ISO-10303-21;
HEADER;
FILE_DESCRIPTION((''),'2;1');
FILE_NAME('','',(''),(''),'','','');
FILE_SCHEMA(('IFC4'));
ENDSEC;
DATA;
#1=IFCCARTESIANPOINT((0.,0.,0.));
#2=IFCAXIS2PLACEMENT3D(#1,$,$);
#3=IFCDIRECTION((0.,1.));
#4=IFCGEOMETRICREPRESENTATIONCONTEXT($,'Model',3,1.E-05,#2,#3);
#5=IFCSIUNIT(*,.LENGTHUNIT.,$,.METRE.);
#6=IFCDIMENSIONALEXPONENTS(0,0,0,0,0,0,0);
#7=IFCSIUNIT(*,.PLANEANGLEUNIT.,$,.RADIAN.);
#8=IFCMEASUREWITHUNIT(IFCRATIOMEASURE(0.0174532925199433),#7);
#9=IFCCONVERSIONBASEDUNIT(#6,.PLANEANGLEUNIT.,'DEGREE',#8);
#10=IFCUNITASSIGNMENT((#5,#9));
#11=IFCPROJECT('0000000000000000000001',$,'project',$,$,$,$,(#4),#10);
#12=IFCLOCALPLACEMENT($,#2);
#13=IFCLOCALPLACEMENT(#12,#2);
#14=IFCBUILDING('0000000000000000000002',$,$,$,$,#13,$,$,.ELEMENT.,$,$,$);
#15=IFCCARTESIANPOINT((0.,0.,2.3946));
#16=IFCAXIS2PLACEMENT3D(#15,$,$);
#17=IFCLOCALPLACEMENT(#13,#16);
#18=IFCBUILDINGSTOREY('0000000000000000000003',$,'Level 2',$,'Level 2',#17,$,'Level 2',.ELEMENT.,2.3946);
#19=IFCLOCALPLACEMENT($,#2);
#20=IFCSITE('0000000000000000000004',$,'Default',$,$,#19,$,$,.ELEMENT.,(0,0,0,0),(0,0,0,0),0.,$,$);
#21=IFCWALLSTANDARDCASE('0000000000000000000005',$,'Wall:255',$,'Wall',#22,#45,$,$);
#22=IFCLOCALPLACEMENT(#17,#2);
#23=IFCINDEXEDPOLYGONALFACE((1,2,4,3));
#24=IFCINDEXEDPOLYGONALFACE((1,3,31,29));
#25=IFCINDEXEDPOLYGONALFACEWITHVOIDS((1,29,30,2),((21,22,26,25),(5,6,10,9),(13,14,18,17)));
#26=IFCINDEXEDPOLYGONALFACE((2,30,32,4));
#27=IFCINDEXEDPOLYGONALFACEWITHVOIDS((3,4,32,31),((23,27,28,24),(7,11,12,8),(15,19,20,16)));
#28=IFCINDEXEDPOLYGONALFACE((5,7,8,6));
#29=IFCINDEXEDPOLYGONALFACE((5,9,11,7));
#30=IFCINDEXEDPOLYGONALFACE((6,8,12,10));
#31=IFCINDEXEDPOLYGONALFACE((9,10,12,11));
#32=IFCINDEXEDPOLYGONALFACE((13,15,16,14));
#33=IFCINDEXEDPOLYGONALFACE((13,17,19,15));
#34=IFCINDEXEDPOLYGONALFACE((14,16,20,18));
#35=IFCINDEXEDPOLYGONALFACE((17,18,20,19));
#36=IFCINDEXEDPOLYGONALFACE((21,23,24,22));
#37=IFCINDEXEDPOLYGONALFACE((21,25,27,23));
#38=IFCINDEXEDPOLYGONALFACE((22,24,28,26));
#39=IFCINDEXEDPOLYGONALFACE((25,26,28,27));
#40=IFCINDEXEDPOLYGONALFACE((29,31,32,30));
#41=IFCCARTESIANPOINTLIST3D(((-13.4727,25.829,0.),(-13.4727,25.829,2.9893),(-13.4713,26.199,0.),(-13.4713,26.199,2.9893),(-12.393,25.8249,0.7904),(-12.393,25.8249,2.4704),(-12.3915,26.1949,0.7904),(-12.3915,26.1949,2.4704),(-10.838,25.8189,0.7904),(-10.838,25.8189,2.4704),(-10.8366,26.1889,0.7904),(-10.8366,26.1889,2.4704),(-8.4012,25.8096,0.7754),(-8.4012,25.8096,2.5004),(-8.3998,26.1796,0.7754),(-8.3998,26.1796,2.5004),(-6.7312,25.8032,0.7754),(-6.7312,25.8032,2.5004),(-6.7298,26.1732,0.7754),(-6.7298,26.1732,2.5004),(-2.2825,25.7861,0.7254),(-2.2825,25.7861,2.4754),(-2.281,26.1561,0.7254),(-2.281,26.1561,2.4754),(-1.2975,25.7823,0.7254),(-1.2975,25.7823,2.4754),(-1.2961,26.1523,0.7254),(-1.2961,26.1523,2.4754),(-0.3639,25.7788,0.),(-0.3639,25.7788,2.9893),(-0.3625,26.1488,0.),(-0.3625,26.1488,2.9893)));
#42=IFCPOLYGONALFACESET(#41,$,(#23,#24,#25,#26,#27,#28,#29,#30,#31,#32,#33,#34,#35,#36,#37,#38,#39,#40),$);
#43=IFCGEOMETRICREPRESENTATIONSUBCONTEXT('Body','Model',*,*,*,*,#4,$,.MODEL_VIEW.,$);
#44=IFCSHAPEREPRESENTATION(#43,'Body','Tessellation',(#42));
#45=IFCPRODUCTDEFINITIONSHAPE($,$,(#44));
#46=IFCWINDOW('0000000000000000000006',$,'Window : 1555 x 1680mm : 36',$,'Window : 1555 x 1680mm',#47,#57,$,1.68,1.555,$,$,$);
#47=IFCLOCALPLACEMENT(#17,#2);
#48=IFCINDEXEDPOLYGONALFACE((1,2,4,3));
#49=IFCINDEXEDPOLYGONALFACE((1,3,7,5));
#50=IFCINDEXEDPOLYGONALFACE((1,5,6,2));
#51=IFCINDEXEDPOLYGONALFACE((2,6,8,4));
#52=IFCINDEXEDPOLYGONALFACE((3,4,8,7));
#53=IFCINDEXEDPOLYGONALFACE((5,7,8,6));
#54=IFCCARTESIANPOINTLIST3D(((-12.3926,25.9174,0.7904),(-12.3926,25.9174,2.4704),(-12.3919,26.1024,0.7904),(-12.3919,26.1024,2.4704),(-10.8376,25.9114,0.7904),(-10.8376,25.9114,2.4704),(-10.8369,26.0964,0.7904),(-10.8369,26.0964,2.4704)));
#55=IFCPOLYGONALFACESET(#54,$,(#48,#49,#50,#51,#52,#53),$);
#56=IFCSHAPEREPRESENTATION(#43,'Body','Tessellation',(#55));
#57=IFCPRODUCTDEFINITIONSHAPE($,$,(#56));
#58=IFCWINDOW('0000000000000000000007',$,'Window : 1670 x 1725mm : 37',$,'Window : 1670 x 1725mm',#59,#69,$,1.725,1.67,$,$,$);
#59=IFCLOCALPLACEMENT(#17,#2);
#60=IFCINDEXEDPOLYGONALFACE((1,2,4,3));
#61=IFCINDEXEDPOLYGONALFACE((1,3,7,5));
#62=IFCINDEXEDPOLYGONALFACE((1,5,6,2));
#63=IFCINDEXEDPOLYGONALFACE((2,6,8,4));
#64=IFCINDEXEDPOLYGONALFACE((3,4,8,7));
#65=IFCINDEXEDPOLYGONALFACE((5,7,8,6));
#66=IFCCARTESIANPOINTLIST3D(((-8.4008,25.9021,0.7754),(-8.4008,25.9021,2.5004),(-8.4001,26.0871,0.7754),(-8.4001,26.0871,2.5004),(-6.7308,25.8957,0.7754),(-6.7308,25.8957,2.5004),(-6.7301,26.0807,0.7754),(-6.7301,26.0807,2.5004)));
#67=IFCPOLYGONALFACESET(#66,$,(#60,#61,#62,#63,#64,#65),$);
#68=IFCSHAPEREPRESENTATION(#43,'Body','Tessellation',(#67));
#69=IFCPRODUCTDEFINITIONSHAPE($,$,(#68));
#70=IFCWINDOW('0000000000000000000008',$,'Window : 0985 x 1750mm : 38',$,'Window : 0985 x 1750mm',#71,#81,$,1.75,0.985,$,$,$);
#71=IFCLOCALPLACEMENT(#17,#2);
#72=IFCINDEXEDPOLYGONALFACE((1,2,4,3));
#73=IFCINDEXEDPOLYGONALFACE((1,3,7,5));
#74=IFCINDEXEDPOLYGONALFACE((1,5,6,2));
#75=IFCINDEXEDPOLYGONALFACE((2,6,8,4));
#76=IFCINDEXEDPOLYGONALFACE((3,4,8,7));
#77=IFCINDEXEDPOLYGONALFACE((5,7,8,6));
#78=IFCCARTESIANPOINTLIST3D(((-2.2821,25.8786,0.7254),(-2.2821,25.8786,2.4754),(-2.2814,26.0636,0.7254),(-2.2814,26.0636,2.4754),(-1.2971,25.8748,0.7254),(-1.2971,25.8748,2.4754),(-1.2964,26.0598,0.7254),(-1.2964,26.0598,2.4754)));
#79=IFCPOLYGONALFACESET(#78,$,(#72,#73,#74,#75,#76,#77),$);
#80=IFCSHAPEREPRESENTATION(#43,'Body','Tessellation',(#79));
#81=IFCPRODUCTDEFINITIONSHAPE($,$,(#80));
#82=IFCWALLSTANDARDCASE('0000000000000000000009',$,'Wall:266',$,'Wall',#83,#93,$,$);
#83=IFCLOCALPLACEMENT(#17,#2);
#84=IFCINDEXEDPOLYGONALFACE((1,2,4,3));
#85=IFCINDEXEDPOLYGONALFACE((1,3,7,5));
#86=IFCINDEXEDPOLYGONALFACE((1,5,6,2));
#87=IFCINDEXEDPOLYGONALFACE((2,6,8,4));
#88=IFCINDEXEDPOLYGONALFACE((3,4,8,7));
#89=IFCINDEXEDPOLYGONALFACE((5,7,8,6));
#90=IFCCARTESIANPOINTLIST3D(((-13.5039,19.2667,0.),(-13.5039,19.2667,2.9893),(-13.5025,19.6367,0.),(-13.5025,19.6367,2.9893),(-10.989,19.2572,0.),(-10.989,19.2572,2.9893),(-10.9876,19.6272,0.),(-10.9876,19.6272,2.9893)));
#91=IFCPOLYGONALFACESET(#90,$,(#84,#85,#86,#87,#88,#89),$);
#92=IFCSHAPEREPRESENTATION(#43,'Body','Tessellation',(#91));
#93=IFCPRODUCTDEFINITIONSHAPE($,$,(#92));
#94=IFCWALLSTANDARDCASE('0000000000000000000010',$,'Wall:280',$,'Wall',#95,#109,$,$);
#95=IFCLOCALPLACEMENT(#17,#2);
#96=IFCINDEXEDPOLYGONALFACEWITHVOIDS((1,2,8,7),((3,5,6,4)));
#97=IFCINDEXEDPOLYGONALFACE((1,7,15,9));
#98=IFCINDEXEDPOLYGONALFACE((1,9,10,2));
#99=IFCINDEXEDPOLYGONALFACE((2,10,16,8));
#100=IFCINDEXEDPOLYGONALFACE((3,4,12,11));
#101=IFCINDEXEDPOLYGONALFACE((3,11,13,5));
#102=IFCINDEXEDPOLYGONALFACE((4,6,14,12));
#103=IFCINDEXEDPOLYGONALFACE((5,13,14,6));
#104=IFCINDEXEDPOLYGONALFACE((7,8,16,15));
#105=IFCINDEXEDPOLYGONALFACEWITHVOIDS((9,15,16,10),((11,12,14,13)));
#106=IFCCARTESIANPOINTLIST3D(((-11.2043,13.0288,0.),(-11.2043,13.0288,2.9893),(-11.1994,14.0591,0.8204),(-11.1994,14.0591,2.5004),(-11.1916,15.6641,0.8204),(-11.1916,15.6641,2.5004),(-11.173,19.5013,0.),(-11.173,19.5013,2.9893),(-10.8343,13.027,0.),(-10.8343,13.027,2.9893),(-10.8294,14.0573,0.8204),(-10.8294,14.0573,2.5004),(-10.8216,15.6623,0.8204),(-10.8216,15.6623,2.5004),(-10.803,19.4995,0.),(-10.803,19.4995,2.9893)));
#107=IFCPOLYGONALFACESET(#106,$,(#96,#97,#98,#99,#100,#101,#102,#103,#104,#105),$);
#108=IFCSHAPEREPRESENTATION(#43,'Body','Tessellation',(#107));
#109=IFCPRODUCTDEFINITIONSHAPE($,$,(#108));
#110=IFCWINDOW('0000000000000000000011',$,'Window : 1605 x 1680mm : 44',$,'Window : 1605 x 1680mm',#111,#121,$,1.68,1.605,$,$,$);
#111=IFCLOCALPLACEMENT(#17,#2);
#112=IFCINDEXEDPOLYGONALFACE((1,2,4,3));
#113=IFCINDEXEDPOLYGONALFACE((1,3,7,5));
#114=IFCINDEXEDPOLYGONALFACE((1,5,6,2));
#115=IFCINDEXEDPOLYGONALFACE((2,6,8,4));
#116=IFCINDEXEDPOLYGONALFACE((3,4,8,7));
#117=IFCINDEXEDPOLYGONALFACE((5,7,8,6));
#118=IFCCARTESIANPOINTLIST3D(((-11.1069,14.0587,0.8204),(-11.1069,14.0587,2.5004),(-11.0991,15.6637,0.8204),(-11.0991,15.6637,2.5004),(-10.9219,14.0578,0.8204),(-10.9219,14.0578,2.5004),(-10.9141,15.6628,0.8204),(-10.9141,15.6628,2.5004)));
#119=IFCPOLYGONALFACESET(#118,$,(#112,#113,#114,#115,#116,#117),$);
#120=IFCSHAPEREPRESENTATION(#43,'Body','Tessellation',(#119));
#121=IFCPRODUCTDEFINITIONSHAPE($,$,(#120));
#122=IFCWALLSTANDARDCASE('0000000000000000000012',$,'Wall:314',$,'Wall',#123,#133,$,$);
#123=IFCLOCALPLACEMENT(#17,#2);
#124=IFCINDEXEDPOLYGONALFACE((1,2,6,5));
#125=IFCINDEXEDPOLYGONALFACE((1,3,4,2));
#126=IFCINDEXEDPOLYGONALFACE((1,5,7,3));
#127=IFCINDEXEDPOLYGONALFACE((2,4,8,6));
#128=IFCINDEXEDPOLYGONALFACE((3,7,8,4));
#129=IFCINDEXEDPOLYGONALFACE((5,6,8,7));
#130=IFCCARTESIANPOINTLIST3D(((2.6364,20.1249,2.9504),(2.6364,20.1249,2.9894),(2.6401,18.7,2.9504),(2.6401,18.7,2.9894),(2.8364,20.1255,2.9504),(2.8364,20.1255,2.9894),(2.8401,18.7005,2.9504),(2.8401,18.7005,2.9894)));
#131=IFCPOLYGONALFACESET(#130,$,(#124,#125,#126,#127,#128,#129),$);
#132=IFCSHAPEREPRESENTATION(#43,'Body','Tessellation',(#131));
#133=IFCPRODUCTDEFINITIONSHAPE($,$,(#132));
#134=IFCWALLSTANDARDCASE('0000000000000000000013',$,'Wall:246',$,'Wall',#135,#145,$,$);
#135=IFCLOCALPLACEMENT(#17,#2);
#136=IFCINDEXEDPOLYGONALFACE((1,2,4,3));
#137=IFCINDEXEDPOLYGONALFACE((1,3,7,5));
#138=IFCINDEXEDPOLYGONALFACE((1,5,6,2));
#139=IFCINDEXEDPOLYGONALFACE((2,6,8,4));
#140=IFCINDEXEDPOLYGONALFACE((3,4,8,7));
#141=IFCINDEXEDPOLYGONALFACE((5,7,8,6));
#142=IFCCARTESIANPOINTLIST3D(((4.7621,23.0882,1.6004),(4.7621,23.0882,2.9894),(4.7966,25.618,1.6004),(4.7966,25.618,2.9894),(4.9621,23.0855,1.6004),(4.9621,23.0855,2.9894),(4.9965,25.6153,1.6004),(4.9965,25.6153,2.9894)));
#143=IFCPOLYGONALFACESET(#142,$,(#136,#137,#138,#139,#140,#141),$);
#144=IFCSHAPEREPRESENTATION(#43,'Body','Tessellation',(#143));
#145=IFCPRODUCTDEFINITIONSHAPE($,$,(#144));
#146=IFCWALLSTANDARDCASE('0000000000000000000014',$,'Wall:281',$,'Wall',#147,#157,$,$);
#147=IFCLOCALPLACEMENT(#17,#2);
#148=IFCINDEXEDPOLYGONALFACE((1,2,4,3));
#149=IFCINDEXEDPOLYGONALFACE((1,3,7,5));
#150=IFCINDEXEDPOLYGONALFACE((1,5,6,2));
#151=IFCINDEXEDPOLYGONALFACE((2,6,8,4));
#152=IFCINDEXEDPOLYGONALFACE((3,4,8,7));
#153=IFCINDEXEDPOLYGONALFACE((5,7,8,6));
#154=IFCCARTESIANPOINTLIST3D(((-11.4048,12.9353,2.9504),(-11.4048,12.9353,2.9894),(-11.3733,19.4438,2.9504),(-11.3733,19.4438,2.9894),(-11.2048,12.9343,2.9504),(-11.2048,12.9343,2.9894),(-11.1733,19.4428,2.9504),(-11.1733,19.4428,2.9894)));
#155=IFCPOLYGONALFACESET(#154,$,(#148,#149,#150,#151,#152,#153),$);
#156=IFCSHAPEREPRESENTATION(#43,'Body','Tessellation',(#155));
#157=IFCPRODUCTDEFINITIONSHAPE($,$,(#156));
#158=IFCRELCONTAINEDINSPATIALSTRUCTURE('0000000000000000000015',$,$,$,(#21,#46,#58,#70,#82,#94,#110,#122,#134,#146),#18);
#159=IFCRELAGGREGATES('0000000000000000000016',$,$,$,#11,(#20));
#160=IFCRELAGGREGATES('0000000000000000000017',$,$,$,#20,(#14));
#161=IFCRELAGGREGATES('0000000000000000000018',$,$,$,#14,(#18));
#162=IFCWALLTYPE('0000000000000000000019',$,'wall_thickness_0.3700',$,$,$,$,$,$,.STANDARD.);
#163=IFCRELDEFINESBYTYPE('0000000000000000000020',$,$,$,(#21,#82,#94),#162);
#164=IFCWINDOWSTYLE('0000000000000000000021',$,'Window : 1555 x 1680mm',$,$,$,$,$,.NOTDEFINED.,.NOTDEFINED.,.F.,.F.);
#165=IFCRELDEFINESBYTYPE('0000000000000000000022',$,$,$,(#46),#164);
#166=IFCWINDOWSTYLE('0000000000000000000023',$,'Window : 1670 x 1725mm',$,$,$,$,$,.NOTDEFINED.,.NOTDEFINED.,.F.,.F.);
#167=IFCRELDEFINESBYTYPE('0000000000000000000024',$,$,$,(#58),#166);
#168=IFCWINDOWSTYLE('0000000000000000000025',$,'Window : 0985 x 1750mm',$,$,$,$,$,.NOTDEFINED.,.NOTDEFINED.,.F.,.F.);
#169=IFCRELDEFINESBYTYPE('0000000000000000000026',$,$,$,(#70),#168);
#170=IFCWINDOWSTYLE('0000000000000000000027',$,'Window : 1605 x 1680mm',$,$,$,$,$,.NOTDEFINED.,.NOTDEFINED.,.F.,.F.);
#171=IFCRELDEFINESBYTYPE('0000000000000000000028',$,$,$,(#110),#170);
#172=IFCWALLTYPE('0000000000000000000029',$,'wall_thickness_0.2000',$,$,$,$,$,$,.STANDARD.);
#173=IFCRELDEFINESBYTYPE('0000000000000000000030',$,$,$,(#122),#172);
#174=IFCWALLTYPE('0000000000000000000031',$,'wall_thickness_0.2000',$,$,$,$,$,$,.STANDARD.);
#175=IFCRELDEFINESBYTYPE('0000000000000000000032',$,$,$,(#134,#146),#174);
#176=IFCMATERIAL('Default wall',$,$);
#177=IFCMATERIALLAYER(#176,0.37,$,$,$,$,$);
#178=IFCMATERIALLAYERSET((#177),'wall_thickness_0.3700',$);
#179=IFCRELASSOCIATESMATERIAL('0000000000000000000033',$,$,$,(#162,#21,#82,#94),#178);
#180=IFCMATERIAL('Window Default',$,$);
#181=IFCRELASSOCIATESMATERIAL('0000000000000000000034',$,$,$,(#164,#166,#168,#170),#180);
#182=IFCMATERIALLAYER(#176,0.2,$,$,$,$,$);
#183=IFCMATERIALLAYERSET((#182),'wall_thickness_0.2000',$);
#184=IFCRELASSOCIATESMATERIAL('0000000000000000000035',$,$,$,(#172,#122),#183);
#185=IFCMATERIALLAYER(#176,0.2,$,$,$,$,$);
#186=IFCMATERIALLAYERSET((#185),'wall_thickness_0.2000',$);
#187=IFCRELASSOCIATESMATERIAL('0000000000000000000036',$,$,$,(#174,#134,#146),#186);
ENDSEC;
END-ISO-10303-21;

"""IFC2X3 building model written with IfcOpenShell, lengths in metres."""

from ifc_helpers import new_model, entity, si_unit, converted_unit, direction, frame, frame_2d, origin, origin_2d_with_axis, place, context, subcontext, project, spatial, polyline, rectangle, outline, extrude, source, transform, mapped, material, layer, layer_set, layer_usage, type_object, type_shapes, element, fill, save


model = new_model("IFC2X3")

# Units and contexts
model_context = context("Model", 3, precision=1e-05, world=origin(), true_north=direction((0.0, 1.0)))
body_context = subcontext(model_context, "Body", "Model", "MODEL_VIEW")
ifc_project = project(units=[si_unit("LENGTHUNIT", "METRE"), converted_unit("PLANEANGLEUNIT", "DEGREE", entity("IfcRatioMeasure", 0.0174532925199433), si_unit("PLANEANGLEUNIT", "RADIAN"), dimensions=[0, 0, 0, 0, 0, 0, 0])], contexts=[model_context])

# Site, building, storey
site_placement = place(None, origin())
site = spatial("IfcSite", under=ifc_project, at=site_placement, Name="Default", CompositionType="ELEMENT", RefLatitude=(0, 0, 0, 0), RefLongitude=(0, 0, 0, 0), RefElevation=0.0)
placement_1 = place(None, origin())
building_placement = place(placement_1, origin())
building = spatial("IfcBuilding", under=site, at=building_placement, CompositionType="ELEMENT")
storey_placement = place(building_placement, frame((0.0, 0.0, 2.3946)))
storey = spatial("IfcBuildingStorey", under=building, at=storey_placement, Name="Level 2", ObjectType="Level 2", LongName="Level 2", CompositionType="ELEMENT", Elevation=2.3946)

# Wall, openings, windows
ifc_material_1 = material(Name="Default wall")
ifc_layer_1 = layer(ifc_material_1, 0.37)
ifc_layer_set_1 = layer_set([ifc_layer_1], Name="wall_thickness_0.3700")
ifc_layer_usage_1 = layer_usage(ifc_layer_set_1, "AXIS2", "POSITIVE", -0.185)
wall_type_1 = type_object("IfcWallType", Name="wall_thickness_0.3700", PredefinedType="STANDARD", material=ifc_layer_set_1)
wall_1_placement = place(storey_placement, frame((-13.472, 26.014, 0.0), z_axis=(0.0, 0.0, 1.0), x_axis=(0.999993, -0.003831, 0.0)))
wall_1 = element("IfcWallStandardCase", 1, at=wall_1_placement, inside=storey, type_object=wall_type_1, material=ifc_layer_usage_1, Name="Wall:255", ObjectType="Wall", context=body_context, shape_type="SweptSolid", body=[
    extrude(outline(polyline([(13.1089, -0.185), (13.1089, 0.185), (0.0, 0.185), (0.0, -0.185), (13.1089, -0.185)])), origin(), (0.0, 0.0, 1.0), 2.9893),
])
opening_1_placement = place(wall_1_placement, frame((1.0798, -0.185, 0.7904)))
opening_1 = element("IfcOpeningElement", 2, at=opening_1_placement, cuts=wall_1, ObjectType="Opening", context=body_context, shape_type="SweptSolid", body=[
    extrude(rectangle(XDim=1.555, YDim=1.68, at=frame_2d((0.84, 0.7775), x_axis=(0.0, 1.0))), frame((0.0, 0.0, 0.0), z_axis=(0.0, 1.0, 0.0), x_axis=(0.0, 0.0, 1.0)), (0.0, 0.0, 1.0), 0.37),
])
opening_2_placement = place(wall_1_placement, frame((5.0716, -0.185, 0.7754)))
opening_2 = element("IfcOpeningElement", 3, at=opening_2_placement, cuts=wall_1, ObjectType="Opening", context=body_context, shape_type="SweptSolid", body=[
    extrude(rectangle(XDim=1.67, YDim=1.725, at=frame_2d((0.8625, 0.835), x_axis=(0.0, 1.0))), frame((0.0, 0.0, 0.0), z_axis=(0.0, 1.0, 0.0), x_axis=(0.0, 0.0, 1.0)), (0.0, 0.0, 1.0), 0.37),
])
opening_3_placement = place(wall_1_placement, frame((11.1903, -0.185, 0.7254)))
opening_3 = element("IfcOpeningElement", 4, at=opening_3_placement, cuts=wall_1, ObjectType="Opening", context=body_context, shape_type="SweptSolid", body=[
    extrude(rectangle(XDim=0.985, YDim=1.75, at=frame_2d((0.875, 0.4925), x_axis=(0.0, 1.0))), frame((0.0, 0.0, 0.0), z_axis=(0.0, 1.0, 0.0), x_axis=(0.0, 0.0, 1.0)), (0.0, 0.0, 1.0), 0.37),
])
ifc_material_2 = material(Name="Window Default")
window_style_1 = type_object("IfcWindowStyle", Name="Window : 1555 x 1680mm", ConstructionType="NOTDEFINED", OperationType="NOTDEFINED", ParameterTakesPrecedence=False, Sizeable=False, material=ifc_material_2)
shared_shape_1 = source(origin(), body_context, "Body", "SweptSolid", [
    extrude(rectangle(XDim=0.185, YDim=1.555, at=origin_2d_with_axis()), frame((0.7775, 0.185, 0.0), z_axis=(0.0, 0.0, 1.0), x_axis=(0.0, 1.0, 0.0)), (0.0, 0.0, 1.0), 1.68),
])
type_shapes(window_style_1, [shared_shape_1])
window_1_placement = place(opening_1_placement, origin())
window_1 = element("IfcWindow", 5, at=window_1_placement, inside=storey, type_object=window_style_1, Name="Window : 1555 x 1680mm : 36", ObjectType="Window : 1555 x 1680mm", OverallHeight=1.68, OverallWidth=1.555, context=body_context, shape_type="MappedRepresentation", body=[
    mapped(shared_shape_1, transform((0.0, 0.0, 0.0), scale=1.0)),
])
fill(opening_1, window_1)
window_style_2 = type_object("IfcWindowStyle", Name="Window : 1670 x 1725mm", ConstructionType="NOTDEFINED", OperationType="NOTDEFINED", ParameterTakesPrecedence=False, Sizeable=False, material=ifc_material_2)
shared_shape_2 = source(origin(), body_context, "Body", "SweptSolid", [
    extrude(rectangle(XDim=0.185, YDim=1.67, at=origin_2d_with_axis()), frame((0.835, 0.185, 0.0), z_axis=(0.0, 0.0, 1.0), x_axis=(0.0, 1.0, 0.0)), (0.0, 0.0, 1.0), 1.725),
])
type_shapes(window_style_2, [shared_shape_2])
window_2_placement = place(opening_2_placement, origin())
window_2 = element("IfcWindow", 6, at=window_2_placement, inside=storey, type_object=window_style_2, Name="Window : 1670 x 1725mm : 37", ObjectType="Window : 1670 x 1725mm", OverallHeight=1.725, OverallWidth=1.67, context=body_context, shape_type="MappedRepresentation", body=[
    mapped(shared_shape_2, transform((0.0, 0.0, 0.0), scale=1.0)),
])
fill(opening_2, window_2)
window_style_3 = type_object("IfcWindowStyle", Name="Window : 0985 x 1750mm", ConstructionType="NOTDEFINED", OperationType="NOTDEFINED", ParameterTakesPrecedence=False, Sizeable=False, material=ifc_material_2)
shared_shape_3 = source(origin(), body_context, "Body", "SweptSolid", [
    extrude(rectangle(XDim=0.185, YDim=0.985, at=origin_2d_with_axis()), frame((0.4925, 0.185, 0.0), z_axis=(0.0, 0.0, 1.0), x_axis=(0.0, 1.0, 0.0)), (0.0, 0.0, 1.0), 1.75),
])
type_shapes(window_style_3, [shared_shape_3])
window_3_placement = place(opening_3_placement, origin())
window_3 = element("IfcWindow", 7, at=window_3_placement, inside=storey, type_object=window_style_3, Name="Window : 0985 x 1750mm : 38", ObjectType="Window : 0985 x 1750mm", OverallHeight=1.75, OverallWidth=0.985, context=body_context, shape_type="MappedRepresentation", body=[
    mapped(shared_shape_3, transform((0.0, 0.0, 0.0), scale=1.0)),
])
fill(opening_3, window_3)

# Wall
wall_2_placement = place(storey_placement, frame((-13.5032, 19.4517, 0.0), z_axis=(0.0, 0.0, 1.0), x_axis=(0.999993, -0.003752, 0.0)))
element("IfcWallStandardCase", 8, at=wall_2_placement, inside=storey, type_object=wall_type_1, material=ifc_layer_usage_1, Name="Wall:266", ObjectType="Wall", context=body_context, shape_type="SweptSolid", body=[
    extrude(outline(polyline([(2.5149, -0.185), (2.5149, 0.185), (0.0, 0.185), (0.0, -0.185), (2.5149, -0.185)])), origin(), (0.0, 0.0, 1.0), 2.9893),
])

# Wall, opening, window
wall_3_placement = place(storey_placement, frame((-10.988, 19.5004, 0.0), z_axis=(0.0, 0.0, 1.0), x_axis=(-0.004837, -0.999988, 0.0)))
wall_3 = element("IfcWallStandardCase", 9, at=wall_3_placement, inside=storey, type_object=wall_type_1, material=ifc_layer_usage_1, Name="Wall:280", ObjectType="Wall", context=body_context, shape_type="SweptSolid", body=[
    extrude(outline(polyline([(6.4725, -0.185), (6.4725, 0.185), (0.0, 0.185), (0.0, -0.185), (6.4725, -0.185)])), origin(), (0.0, 0.0, 1.0), 2.9893),
])
opening_4_placement = place(wall_3_placement, frame((3.8372, -0.185, 0.8204)))
opening_4 = element("IfcOpeningElement", 10, at=opening_4_placement, cuts=wall_3, ObjectType="Opening", context=body_context, shape_type="SweptSolid", body=[
    extrude(rectangle(XDim=1.605, YDim=1.68, at=frame_2d((0.84, 0.8025), x_axis=(0.0, 1.0))), frame((0.0, 0.0, 0.0), z_axis=(0.0, 1.0, 0.0), x_axis=(0.0, 0.0, 1.0)), (0.0, 0.0, 1.0), 0.37),
])
window_style_4 = type_object("IfcWindowStyle", Name="Window : 1605 x 1680mm", ConstructionType="NOTDEFINED", OperationType="NOTDEFINED", ParameterTakesPrecedence=False, Sizeable=False, material=ifc_material_2)
shared_shape_4 = source(origin(), body_context, "Body", "SweptSolid", [
    extrude(rectangle(XDim=0.185, YDim=1.605, at=origin_2d_with_axis()), frame((0.8025, 0.185, 0.0), z_axis=(0.0, 0.0, 1.0), x_axis=(0.0, 1.0, 0.0)), (0.0, 0.0, 1.0), 1.68),
])
type_shapes(window_style_4, [shared_shape_4])
window_4_placement = place(opening_4_placement, origin())
window_4 = element("IfcWindow", 11, at=window_4_placement, inside=storey, type_object=window_style_4, Name="Window : 1605 x 1680mm : 44", ObjectType="Window : 1605 x 1680mm", OverallHeight=1.68, OverallWidth=1.605, context=body_context, shape_type="MappedRepresentation", body=[
    mapped(shared_shape_4, transform((0.0, 0.0, 0.0), scale=1.0)),
])
fill(opening_4, window_4)

# Walls
ifc_layer_2 = layer(ifc_material_1, 0.2)
ifc_layer_set_2 = layer_set([ifc_layer_2], Name="wall_thickness_0.2000")
ifc_layer_usage_2 = layer_usage(ifc_layer_set_2, "AXIS2", "POSITIVE", -0.1)
wall_type_2 = type_object("IfcWallType", Name="wall_thickness_0.2000", PredefinedType="STANDARD", material=ifc_layer_set_2)
placement_2 = place(building_placement, frame((0.0, 0.0, 5.345)))
wall_4_placement = place(placement_2, frame((2.7364, 20.1252, 0.0), z_axis=(0.0, 0.0, 1.0), x_axis=(0.002619, -0.999997, 0.0)))
element("IfcWallStandardCase", 12, at=wall_4_placement, inside=storey, type_object=wall_type_2, material=ifc_layer_usage_2, Name="Wall:314", ObjectType="Wall", context=body_context, shape_type="SweptSolid", body=[
    extrude(outline(polyline([(1.425, -0.1), (1.425, 0.1), (0.0, 0.1), (0.0, -0.1), (1.425, -0.1)])), origin(), (0.0, 0.0, 1.0), 0.039),
])
ifc_layer_3 = layer(ifc_material_1, 0.2)
ifc_layer_set_3 = layer_set([ifc_layer_3], Name="wall_thickness_0.2000")
ifc_layer_usage_3 = layer_usage(ifc_layer_set_3, "AXIS2", "POSITIVE", -0.1)
wall_type_3 = type_object("IfcWallType", Name="wall_thickness_0.2000", PredefinedType="STANDARD", material=ifc_layer_set_3)
placement_3 = place(building_placement, frame((0.0, 0.0, 3.995)))
wall_5_placement = place(placement_3, frame((4.8621, 23.0869, 0.0), z_axis=(0.0, 0.0, 1.0), x_axis=(0.013609, 0.999907, 0.0)))
element("IfcWallStandardCase", 13, at=wall_5_placement, inside=storey, type_object=wall_type_3, material=ifc_layer_usage_3, Name="Wall:246", ObjectType="Wall", context=body_context, shape_type="SweptSolid", body=[
    extrude(outline(polyline([(2.53, -0.1), (2.53, 0.1), (0.0, 0.1), (0.0, -0.1), (2.53, -0.1)])), origin(), (0.0, 0.0, 1.0), 1.389),
])
placement_4 = place(building_placement, frame((0.0, 0.0, 5.345)))
wall_6_placement = place(placement_4, frame((-11.2733, 19.4433, 0.0), z_axis=(0.0, 0.0, 1.0), x_axis=(-0.004838, -0.999988, 0.0)))
element("IfcWallStandardCase", 14, at=wall_6_placement, inside=storey, type_object=wall_type_3, material=ifc_layer_usage_3, Name="Wall:281", ObjectType="Wall", context=body_context, shape_type="SweptSolid", body=[
    extrude(outline(polyline([(6.5086, -0.1), (6.5086, 0.1), (0.0, 0.1), (0.0, -0.1), (6.5086, -0.1)])), origin(), (0.0, 0.0, 1.0), 0.039),
])

save(model, "model.ifc")
